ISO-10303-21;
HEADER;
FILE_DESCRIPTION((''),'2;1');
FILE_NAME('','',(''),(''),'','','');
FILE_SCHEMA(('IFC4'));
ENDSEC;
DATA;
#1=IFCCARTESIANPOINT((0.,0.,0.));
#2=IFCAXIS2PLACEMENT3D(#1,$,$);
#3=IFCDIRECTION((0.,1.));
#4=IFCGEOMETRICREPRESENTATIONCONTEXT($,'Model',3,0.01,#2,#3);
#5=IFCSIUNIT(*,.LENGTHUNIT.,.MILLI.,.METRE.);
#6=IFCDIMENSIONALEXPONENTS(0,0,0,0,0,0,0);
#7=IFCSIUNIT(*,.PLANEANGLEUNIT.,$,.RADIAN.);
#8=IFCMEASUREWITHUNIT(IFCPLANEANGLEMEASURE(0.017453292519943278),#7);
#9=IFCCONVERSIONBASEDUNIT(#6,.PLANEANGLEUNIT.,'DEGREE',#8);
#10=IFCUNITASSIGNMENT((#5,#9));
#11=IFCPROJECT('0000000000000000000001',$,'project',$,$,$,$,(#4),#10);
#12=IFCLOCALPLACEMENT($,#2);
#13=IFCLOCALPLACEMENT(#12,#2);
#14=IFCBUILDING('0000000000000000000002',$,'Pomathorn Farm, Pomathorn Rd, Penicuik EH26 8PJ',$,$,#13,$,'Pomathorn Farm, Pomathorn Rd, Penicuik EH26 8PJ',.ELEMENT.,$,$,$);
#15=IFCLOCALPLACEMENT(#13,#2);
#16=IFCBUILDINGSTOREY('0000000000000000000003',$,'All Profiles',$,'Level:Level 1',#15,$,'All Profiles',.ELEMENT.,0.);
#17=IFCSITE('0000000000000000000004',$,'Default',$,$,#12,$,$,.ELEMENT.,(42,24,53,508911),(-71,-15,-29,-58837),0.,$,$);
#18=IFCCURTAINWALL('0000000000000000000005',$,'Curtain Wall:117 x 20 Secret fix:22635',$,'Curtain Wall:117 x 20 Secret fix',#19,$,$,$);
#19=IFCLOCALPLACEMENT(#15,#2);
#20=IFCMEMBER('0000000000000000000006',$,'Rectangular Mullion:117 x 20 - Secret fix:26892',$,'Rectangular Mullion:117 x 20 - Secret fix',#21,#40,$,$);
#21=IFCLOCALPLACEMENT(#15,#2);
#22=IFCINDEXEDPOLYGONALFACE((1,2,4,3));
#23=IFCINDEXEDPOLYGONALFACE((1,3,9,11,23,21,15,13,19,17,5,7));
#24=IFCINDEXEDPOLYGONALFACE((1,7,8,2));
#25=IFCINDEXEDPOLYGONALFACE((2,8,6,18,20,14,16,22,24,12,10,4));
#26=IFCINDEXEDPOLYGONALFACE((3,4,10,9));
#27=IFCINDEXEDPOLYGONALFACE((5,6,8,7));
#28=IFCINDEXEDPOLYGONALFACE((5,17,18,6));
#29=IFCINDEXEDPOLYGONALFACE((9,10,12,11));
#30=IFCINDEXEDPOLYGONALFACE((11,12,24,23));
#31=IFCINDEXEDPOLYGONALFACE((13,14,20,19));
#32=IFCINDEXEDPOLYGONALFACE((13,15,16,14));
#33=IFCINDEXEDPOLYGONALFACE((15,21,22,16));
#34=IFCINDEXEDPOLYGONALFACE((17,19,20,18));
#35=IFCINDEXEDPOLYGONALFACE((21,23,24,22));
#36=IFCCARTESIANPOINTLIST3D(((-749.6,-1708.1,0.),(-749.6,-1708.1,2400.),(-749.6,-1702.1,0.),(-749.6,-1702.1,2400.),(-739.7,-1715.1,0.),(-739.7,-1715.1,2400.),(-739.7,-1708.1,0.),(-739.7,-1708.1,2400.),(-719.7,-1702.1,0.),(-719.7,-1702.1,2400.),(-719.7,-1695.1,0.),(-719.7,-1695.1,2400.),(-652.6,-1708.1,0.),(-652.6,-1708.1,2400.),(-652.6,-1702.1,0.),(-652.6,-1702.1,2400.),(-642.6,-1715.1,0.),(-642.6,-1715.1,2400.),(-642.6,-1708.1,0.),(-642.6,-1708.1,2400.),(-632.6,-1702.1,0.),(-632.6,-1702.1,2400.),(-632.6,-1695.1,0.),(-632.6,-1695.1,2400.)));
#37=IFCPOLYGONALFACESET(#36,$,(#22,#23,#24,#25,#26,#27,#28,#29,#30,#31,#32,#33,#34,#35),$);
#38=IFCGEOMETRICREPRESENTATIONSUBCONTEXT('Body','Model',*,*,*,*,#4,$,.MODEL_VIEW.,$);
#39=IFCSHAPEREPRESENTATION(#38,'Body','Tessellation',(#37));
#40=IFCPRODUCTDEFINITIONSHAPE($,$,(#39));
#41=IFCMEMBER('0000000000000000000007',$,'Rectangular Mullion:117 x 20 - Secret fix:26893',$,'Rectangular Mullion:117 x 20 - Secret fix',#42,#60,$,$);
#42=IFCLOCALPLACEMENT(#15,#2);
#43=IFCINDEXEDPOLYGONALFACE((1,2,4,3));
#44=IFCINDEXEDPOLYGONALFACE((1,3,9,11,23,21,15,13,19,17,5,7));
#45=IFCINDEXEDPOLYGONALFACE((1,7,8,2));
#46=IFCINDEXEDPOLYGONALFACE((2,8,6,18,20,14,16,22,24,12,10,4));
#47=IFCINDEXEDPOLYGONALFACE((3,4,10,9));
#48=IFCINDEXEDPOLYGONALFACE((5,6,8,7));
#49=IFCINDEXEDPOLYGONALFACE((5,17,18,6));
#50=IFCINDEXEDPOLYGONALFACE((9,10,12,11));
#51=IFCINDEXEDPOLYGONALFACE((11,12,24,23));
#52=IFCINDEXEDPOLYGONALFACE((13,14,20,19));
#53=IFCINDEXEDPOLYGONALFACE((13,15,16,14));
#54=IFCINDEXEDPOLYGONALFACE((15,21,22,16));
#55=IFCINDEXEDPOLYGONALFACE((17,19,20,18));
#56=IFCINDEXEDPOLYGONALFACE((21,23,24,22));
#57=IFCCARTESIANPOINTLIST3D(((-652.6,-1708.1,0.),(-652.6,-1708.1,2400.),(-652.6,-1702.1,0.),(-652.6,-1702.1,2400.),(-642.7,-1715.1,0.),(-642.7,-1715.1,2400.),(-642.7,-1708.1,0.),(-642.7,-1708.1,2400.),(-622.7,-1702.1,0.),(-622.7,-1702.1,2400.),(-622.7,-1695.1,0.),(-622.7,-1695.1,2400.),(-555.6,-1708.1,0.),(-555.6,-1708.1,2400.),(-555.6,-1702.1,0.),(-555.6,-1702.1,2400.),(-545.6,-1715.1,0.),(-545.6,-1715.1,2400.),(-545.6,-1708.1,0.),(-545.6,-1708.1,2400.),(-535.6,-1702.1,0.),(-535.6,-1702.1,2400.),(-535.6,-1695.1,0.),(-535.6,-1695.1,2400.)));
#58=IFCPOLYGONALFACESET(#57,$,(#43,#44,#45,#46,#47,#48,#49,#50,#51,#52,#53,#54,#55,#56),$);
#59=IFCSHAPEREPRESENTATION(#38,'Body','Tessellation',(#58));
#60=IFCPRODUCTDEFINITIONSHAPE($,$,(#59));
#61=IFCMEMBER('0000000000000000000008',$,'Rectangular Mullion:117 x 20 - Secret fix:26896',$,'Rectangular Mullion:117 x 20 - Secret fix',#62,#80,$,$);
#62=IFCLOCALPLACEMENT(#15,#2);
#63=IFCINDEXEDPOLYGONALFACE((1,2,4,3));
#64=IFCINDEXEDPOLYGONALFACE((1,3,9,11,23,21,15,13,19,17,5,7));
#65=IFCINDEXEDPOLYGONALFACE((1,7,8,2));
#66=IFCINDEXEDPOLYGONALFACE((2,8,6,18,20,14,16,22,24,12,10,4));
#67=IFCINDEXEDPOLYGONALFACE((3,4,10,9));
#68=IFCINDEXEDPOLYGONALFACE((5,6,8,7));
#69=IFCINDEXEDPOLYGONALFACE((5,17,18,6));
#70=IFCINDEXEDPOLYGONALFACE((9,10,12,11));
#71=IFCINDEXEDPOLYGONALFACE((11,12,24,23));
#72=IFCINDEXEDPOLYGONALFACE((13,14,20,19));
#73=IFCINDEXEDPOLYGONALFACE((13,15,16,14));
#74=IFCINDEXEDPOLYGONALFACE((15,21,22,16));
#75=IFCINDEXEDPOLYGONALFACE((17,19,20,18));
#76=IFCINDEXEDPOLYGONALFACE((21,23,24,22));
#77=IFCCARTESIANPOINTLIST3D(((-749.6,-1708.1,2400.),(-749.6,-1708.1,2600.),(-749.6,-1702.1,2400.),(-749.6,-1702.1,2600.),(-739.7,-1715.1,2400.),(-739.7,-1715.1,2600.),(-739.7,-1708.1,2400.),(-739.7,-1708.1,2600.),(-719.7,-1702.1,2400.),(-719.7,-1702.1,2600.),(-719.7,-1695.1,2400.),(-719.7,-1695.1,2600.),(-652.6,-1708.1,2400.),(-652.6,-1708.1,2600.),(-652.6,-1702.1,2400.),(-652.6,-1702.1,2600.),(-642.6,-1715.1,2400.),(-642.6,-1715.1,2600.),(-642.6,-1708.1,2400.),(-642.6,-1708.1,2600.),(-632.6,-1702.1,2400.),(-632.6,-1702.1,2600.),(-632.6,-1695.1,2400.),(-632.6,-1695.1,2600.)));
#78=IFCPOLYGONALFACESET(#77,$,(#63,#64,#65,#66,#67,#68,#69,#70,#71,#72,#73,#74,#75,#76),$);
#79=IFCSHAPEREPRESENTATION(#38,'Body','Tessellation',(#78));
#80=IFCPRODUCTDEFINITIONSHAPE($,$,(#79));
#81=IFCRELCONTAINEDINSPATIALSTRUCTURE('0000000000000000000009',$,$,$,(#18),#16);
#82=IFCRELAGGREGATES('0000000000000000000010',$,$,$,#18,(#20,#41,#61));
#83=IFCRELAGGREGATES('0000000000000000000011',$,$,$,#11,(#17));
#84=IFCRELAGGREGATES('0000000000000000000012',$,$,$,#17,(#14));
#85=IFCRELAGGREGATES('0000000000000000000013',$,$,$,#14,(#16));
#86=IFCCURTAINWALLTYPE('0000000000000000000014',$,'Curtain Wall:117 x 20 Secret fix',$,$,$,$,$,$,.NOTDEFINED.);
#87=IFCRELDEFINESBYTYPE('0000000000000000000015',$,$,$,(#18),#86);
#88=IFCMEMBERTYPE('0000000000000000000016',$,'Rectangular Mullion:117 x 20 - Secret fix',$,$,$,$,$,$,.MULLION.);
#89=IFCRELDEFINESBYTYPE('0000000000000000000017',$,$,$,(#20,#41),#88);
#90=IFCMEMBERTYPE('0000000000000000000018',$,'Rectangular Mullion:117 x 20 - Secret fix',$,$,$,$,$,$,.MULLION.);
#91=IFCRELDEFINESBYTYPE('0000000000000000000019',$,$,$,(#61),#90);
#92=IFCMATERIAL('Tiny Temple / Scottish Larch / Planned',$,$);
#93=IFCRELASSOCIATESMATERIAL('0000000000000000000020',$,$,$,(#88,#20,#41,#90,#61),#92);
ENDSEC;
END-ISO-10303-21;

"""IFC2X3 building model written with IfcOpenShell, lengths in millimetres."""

from ifc_helpers import new_model, entity, si_unit, converted_unit, direction, frame, origin, place, context, subcontext, project, spatial, polyline, outline, extrude, source, transform, mapped, material, type_object, type_shapes, element, aggregate, save


model = new_model("IFC2X3")

# Units and contexts
model_context = context("Model", 3, precision=0.01, world=origin(), true_north=direction((0.0, 1.0)))
body_context = subcontext(model_context, "Body", "Model", "MODEL_VIEW")
ifc_project = project(units=[si_unit("LENGTHUNIT", "METRE", prefix="MILLI"), converted_unit("PLANEANGLEUNIT", "DEGREE", entity("IfcPlaneAngleMeasure", 0.017453292519943278), si_unit("PLANEANGLEUNIT", "RADIAN"), dimensions=[0, 0, 0, 0, 0, 0, 0])], contexts=[model_context])

# Site, building, storey
site_placement = place(None, origin())
site = spatial("IfcSite", under=ifc_project, at=site_placement, Name="Default", CompositionType="ELEMENT", RefLatitude=(42, 24, 53, 508911), RefLongitude=(-71, -15, -29, -58837), RefElevation=0.0)
building_placement = place(site_placement, origin())
building = spatial("IfcBuilding", under=site, at=building_placement, Name="Pomathorn Farm, Pomathorn Rd, Penicuik EH26 8PJ", LongName="Pomathorn Farm, Pomathorn Rd, Penicuik EH26 8PJ", CompositionType="ELEMENT")
storey_placement = place(building_placement, origin())
storey = spatial("IfcBuildingStorey", under=building, at=storey_placement, Name="All Profiles", ObjectType="Level:Level 1", LongName="All Profiles", CompositionType="ELEMENT", Elevation=0.0)

# Curtain wall, members
curtain_wall_type_1 = type_object("IfcCurtainWallType", Name="Curtain Wall:117 x 20 Secret fix", PredefinedType="NOTDEFINED")
curtain_wall_1_placement = place(storey_placement, origin())
curtain_wall_1 = element("IfcCurtainWall", 1, at=curtain_wall_1_placement, inside=storey, type_object=curtain_wall_type_1, Name="Curtain Wall:117 x 20 Secret fix:22635", ObjectType="Curtain Wall:117 x 20 Secret fix")
ifc_material = material(Name="Tiny Temple / Scottish Larch / Planned")
member_type_1 = type_object("IfcMemberType", Name="Rectangular Mullion:117 x 20 - Secret fix", PredefinedType="MULLION", material=ifc_material)
shared_shape_1 = source(origin(), body_context, "Body", "SweptSolid", [
    extrude(outline(polyline([(-3.0, -60.2), (3.0, -60.2), (3.0, -30.2), (10.0, -30.2), (10.0, 56.8), (3.0, 56.8), (3.0, 36.8), (-3.0, 36.8), (-3.0, 46.8), (-10.0, 46.8), (-10.0, -50.2), (-3.0, -50.2), (-3.0, -60.2)])), frame((-56.8, -10.0, -2400.0), z_axis=(0.0, 0.0, 1.0), x_axis=(0.0, -1.0, 0.0)), (0.0, 0.0, 1.0), 2400.0),
])
type_shapes(member_type_1, [shared_shape_1])
member_1_placement = place(curtain_wall_1_placement, frame((-632.6, -1715.1, 0.0), z_axis=(0.0, 0.0, -1.0), x_axis=(1.0, 0.0, 0.0)))
member_1 = element("IfcMember", 2, at=member_1_placement, type_object=member_type_1, material=ifc_material, Name="Rectangular Mullion:117 x 20 - Secret fix:26892", ObjectType="Rectangular Mullion:117 x 20 - Secret fix", context=body_context, shape_type="MappedRepresentation", body=[
    mapped(shared_shape_1, transform((0.0, 0.0, 0.0), scale=1.0)),
])
member_2_placement = place(curtain_wall_1_placement, frame((-535.6, -1715.1, 0.0), z_axis=(0.0, 0.0, -1.0), x_axis=(1.0, 0.0, 0.0)))
member_2 = element("IfcMember", 3, at=member_2_placement, type_object=member_type_1, material=ifc_material, Name="Rectangular Mullion:117 x 20 - Secret fix:26893", ObjectType="Rectangular Mullion:117 x 20 - Secret fix", context=body_context, shape_type="MappedRepresentation", body=[
    mapped(shared_shape_1, transform((0.0, 0.0, 0.0), scale=1.0)),
])
member_type_2 = type_object("IfcMemberType", Name="Rectangular Mullion:117 x 20 - Secret fix", PredefinedType="MULLION", material=ifc_material)
shared_shape_2 = source(origin(), body_context, "Body", "SweptSolid", [
    extrude(outline(polyline([(-3.0, -60.2), (3.0, -60.2), (3.0, -30.2), (10.0, -30.2), (10.0, 56.8), (3.0, 56.8), (3.0, 36.8), (-3.0, 36.8), (-3.0, 46.8), (-10.0, 46.8), (-10.0, -50.2), (-3.0, -50.2), (-3.0, -60.2)])), frame((-56.8, -10.0, -200.0), z_axis=(0.0, 0.0, 1.0), x_axis=(0.0, -1.0, 0.0)), (0.0, 0.0, 1.0), 200.0),
])
type_shapes(member_type_2, [shared_shape_2])
member_3_placement = place(curtain_wall_1_placement, frame((-632.6, -1715.1, 2400.0), z_axis=(0.0, 0.0, -1.0), x_axis=(1.0, 0.0, 0.0)))
member_3 = element("IfcMember", 4, at=member_3_placement, type_object=member_type_2, material=ifc_material, Name="Rectangular Mullion:117 x 20 - Secret fix:26896", ObjectType="Rectangular Mullion:117 x 20 - Secret fix", context=body_context, shape_type="MappedRepresentation", body=[
    mapped(shared_shape_2, transform((0.0, 0.0, 0.0), scale=1.0)),
])
aggregate(curtain_wall_1, [member_1, member_2, member_3])

save(model, "model.ifc")
